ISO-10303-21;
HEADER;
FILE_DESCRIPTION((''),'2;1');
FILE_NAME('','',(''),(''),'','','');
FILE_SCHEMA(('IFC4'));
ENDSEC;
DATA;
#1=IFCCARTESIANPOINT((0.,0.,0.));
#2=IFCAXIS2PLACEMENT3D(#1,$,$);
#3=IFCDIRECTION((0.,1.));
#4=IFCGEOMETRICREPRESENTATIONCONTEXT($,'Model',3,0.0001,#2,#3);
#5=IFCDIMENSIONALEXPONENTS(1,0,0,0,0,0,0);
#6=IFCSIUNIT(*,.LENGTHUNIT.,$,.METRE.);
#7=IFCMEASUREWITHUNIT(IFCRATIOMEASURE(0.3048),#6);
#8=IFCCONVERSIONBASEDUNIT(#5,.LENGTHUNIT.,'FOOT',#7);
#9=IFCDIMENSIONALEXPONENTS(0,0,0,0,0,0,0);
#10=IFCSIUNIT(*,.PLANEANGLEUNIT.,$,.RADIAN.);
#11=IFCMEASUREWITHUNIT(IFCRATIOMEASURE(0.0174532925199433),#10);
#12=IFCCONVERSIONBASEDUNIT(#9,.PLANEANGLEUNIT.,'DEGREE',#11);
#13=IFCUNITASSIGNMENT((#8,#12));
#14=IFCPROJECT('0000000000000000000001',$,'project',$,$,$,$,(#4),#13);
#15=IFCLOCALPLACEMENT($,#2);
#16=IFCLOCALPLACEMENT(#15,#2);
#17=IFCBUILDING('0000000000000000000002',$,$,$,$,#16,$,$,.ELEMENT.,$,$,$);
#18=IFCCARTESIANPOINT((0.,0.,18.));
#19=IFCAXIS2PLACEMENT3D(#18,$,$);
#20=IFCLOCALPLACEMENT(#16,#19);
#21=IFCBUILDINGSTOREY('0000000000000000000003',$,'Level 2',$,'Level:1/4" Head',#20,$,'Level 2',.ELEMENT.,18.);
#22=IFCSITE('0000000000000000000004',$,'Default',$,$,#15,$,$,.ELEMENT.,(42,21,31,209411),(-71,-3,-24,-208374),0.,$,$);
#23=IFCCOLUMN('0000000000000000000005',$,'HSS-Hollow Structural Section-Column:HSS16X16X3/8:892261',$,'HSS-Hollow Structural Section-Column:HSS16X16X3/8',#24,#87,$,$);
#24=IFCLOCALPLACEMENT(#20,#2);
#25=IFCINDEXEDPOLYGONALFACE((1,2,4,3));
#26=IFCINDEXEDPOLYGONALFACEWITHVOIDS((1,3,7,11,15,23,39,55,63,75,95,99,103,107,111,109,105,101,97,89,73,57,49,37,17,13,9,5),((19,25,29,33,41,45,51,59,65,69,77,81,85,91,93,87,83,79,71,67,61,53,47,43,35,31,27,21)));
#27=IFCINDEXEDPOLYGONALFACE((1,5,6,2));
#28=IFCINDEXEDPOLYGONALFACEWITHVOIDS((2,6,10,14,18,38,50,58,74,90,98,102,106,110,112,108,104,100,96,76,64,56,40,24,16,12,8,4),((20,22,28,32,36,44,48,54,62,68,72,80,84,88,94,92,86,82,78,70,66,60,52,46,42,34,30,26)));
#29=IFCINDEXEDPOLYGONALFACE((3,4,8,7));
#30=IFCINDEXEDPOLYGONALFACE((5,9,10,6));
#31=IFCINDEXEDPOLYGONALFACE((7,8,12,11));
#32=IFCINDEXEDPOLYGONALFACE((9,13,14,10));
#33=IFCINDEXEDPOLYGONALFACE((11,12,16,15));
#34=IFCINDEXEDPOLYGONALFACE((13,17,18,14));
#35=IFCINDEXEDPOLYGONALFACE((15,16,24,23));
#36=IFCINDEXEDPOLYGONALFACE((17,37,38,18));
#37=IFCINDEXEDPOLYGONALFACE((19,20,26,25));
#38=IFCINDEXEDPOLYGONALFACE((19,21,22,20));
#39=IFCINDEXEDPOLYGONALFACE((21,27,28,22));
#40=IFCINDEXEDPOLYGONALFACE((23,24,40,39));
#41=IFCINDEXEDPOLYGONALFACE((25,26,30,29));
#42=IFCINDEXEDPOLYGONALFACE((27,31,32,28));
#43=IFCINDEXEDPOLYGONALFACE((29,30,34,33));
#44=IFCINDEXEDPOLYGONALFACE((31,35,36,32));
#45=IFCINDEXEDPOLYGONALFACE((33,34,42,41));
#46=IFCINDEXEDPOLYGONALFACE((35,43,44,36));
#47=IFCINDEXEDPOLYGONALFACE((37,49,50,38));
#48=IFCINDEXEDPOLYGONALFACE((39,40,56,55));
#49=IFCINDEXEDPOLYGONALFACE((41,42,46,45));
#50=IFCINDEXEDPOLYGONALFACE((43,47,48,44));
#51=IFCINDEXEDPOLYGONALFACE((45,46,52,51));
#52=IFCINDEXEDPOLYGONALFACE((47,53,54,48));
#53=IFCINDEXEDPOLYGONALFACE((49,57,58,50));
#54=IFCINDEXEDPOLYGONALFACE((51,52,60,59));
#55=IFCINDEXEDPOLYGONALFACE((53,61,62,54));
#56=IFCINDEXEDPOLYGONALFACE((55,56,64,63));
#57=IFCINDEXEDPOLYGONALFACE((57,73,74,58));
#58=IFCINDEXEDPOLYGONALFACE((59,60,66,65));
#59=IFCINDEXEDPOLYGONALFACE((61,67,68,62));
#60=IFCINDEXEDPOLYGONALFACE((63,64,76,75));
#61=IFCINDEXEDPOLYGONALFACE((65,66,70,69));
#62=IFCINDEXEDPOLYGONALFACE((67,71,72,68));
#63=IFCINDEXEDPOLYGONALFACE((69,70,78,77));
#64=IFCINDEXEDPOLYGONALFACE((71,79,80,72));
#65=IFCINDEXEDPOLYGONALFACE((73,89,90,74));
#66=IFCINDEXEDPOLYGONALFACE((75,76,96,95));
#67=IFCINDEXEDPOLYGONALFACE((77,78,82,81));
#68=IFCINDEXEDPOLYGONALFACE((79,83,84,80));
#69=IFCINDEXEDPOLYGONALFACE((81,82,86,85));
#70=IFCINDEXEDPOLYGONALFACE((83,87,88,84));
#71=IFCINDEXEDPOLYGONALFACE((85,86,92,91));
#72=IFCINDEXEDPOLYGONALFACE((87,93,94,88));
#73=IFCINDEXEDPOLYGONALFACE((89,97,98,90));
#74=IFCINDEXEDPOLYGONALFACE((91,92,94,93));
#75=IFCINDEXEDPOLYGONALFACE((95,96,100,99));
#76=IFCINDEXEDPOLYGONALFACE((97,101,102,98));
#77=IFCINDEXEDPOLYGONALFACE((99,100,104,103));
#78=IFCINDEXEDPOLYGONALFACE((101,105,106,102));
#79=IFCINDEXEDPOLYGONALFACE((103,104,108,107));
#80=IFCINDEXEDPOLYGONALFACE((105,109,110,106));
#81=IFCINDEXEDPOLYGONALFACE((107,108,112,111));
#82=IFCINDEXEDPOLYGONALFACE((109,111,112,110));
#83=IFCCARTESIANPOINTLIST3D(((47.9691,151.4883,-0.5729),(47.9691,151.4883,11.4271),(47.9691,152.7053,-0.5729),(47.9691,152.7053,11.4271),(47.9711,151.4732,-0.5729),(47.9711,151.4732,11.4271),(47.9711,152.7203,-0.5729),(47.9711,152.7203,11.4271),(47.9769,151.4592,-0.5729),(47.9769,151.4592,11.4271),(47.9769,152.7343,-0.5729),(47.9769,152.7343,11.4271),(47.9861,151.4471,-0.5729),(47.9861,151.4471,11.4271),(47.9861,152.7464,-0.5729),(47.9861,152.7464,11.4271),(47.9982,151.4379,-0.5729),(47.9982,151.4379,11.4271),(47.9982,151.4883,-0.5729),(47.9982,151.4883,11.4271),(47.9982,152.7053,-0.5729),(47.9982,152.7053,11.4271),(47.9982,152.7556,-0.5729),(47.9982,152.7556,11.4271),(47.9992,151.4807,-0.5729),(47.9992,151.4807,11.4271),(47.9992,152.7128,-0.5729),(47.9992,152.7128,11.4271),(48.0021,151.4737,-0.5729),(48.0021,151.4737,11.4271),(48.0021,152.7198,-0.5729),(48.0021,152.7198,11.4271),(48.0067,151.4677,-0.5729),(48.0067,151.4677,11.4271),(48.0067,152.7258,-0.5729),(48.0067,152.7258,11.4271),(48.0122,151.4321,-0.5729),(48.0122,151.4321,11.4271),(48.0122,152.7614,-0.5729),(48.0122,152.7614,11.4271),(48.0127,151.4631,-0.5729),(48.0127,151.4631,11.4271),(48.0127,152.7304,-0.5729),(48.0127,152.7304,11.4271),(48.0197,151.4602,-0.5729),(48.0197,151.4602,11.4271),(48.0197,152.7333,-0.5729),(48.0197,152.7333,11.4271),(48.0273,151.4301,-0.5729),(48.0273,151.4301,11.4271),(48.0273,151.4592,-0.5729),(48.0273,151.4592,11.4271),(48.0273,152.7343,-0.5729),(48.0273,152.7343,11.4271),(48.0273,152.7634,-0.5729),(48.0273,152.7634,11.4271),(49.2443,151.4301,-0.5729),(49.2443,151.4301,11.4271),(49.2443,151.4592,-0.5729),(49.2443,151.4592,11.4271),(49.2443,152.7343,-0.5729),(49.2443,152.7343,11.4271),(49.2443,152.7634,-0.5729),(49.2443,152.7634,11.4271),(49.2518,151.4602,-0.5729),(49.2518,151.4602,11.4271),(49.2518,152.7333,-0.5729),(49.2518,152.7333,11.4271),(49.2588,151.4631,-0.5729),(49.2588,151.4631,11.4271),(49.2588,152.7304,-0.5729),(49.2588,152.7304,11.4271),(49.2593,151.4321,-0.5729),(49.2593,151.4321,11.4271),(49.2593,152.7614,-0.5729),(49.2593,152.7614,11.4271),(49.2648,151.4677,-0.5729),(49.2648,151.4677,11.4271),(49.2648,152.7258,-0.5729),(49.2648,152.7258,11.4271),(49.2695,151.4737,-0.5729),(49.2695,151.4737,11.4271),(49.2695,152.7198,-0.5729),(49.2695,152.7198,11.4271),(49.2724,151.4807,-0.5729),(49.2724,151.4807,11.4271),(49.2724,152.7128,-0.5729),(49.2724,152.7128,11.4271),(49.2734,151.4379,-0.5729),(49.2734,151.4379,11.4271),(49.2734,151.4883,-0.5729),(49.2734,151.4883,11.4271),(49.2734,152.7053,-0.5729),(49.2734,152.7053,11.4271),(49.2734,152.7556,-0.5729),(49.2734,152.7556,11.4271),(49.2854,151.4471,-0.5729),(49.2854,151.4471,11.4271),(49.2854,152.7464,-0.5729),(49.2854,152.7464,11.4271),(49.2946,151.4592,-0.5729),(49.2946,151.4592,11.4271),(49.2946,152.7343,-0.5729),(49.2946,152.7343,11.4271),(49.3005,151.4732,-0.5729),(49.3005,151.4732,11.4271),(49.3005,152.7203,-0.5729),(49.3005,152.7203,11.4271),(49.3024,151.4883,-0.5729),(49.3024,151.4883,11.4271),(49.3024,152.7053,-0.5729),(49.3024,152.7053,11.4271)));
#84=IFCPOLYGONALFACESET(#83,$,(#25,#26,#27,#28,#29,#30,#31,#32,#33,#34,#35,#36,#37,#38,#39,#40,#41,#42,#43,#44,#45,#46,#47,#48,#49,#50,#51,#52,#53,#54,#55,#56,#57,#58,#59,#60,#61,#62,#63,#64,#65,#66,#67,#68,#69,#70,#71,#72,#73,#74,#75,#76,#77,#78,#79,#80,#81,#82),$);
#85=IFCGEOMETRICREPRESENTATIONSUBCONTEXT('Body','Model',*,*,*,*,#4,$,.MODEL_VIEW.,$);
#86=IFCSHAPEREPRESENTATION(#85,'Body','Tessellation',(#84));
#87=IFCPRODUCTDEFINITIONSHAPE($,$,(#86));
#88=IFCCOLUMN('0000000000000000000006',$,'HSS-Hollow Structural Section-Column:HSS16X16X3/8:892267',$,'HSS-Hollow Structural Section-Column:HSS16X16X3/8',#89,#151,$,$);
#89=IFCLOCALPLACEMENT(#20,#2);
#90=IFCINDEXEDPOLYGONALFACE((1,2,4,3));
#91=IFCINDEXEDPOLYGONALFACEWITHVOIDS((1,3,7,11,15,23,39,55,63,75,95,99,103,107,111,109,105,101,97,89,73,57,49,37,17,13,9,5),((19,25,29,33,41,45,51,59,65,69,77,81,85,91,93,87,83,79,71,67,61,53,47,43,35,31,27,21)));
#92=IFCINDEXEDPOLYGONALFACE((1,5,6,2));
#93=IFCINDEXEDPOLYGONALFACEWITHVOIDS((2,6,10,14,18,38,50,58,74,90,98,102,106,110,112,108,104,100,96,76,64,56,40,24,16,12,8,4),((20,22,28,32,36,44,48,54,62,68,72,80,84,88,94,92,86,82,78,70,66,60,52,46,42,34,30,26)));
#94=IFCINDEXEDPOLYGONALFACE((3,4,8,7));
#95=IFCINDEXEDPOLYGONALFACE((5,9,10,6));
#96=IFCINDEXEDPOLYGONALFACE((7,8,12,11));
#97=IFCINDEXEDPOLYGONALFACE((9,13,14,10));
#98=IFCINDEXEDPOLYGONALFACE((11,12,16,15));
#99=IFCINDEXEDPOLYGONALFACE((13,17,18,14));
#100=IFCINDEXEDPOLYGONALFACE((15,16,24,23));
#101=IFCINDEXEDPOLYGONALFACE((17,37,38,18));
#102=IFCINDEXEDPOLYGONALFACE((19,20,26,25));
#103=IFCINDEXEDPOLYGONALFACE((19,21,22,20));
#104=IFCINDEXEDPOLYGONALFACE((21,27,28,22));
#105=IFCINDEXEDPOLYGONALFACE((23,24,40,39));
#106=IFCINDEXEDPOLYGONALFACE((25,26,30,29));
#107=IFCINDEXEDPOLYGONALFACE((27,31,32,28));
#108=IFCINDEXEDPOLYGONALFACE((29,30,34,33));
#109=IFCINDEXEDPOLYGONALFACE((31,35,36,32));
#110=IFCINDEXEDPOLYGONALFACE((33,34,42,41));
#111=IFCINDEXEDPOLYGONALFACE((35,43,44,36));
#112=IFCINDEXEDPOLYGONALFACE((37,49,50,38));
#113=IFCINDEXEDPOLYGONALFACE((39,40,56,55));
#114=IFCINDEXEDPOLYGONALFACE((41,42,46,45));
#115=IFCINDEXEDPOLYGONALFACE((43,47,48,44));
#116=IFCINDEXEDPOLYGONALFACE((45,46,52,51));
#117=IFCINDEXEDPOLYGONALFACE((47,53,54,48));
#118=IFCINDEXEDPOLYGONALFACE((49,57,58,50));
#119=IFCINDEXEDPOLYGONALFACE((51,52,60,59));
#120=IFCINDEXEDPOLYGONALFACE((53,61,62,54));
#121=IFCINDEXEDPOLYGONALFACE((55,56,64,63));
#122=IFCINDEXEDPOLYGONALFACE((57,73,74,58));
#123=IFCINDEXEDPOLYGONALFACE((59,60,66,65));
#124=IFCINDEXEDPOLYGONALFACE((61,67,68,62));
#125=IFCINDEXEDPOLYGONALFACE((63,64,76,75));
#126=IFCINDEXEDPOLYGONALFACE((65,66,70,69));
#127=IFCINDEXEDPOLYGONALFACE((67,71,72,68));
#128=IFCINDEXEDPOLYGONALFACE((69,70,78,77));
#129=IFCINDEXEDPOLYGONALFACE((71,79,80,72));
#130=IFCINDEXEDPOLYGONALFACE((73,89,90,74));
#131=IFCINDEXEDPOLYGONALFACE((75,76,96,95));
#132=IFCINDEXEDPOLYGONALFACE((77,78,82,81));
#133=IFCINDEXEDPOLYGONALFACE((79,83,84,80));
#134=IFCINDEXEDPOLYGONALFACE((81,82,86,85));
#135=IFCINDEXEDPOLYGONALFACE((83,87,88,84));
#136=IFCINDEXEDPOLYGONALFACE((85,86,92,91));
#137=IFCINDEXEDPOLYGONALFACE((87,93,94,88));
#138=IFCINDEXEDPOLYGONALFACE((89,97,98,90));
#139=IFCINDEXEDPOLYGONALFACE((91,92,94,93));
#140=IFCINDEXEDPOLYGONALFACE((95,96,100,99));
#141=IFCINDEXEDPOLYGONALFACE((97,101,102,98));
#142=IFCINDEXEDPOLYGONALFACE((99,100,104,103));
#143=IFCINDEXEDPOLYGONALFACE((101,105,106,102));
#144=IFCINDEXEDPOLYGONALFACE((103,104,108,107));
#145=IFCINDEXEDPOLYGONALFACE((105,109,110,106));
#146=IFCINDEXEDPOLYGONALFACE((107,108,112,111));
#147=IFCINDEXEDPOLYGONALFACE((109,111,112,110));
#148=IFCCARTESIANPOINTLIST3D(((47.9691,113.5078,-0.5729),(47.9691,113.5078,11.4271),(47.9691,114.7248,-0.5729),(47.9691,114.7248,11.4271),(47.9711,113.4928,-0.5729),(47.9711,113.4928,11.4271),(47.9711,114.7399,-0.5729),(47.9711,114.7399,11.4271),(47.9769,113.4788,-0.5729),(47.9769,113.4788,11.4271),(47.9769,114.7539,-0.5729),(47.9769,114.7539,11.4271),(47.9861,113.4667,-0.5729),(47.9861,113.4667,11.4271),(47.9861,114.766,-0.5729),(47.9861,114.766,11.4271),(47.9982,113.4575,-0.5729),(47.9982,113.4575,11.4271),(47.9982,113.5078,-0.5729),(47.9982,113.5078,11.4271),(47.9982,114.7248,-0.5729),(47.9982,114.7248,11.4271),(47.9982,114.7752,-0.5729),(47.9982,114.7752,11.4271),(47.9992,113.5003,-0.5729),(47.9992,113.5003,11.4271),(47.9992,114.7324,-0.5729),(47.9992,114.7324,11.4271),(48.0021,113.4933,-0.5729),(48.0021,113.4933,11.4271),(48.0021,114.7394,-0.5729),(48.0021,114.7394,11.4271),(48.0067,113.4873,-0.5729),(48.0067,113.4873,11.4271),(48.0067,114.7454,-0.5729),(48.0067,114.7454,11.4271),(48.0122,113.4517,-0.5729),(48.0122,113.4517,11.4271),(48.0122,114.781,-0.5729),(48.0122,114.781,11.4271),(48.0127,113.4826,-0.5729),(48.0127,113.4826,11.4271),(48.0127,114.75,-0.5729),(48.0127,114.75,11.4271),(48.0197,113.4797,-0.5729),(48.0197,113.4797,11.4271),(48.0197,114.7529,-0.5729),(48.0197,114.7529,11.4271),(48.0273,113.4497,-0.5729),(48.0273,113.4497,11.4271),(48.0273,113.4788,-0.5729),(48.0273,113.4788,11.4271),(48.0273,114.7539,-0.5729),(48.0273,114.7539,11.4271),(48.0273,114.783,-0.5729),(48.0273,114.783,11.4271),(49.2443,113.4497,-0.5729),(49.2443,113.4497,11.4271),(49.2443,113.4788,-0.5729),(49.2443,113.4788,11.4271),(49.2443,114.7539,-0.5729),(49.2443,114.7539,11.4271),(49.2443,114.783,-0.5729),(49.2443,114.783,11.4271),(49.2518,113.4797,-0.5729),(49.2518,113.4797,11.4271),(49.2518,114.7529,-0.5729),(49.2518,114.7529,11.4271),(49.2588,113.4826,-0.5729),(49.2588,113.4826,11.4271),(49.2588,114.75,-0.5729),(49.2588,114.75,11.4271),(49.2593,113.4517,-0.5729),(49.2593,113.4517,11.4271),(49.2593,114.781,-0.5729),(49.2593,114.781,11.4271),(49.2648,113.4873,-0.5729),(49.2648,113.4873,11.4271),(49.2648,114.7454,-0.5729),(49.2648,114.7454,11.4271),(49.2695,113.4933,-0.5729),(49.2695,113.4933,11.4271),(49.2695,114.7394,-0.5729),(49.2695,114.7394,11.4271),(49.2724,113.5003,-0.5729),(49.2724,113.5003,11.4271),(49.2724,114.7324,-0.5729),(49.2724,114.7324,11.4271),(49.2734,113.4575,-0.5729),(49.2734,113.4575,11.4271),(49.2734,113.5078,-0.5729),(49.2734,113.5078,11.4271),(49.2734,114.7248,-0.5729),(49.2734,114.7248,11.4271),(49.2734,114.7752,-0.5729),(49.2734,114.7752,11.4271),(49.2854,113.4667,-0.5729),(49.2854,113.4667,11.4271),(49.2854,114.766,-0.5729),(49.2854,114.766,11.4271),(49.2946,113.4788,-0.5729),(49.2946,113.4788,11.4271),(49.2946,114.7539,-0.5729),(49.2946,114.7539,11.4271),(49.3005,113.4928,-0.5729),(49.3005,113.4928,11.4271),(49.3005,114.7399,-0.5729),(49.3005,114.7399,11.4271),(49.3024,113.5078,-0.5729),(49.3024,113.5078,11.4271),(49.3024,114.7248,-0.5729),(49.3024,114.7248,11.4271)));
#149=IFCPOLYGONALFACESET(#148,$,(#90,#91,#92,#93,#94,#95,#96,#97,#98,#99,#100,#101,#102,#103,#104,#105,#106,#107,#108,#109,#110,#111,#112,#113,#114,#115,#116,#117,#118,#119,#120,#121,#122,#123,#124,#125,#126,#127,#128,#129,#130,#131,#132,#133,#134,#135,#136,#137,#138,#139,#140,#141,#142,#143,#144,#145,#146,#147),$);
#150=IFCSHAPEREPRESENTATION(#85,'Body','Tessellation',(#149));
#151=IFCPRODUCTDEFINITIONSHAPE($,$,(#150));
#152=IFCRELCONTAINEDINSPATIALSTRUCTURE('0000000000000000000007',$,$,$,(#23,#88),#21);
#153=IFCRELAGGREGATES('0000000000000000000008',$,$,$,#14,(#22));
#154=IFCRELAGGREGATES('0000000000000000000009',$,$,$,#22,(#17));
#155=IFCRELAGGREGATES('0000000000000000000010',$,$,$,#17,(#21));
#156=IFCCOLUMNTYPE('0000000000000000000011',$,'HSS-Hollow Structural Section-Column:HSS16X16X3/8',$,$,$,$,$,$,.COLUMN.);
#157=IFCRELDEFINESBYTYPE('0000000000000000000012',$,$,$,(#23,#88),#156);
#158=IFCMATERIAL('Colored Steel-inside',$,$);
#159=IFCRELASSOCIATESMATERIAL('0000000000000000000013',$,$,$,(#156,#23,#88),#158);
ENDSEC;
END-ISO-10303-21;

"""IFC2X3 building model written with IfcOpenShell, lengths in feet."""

from ifc_helpers import new_model, entity, si_unit, converted_unit, direction, frame, frame_2d, origin, place, context, subcontext, project, spatial, polyline, circle_curve, parameter, trimmed, segment, composite_curve, outline, extrude, source, transform, mapped, material, type_object, type_shapes, element, save


model = new_model("IFC2X3")

# Units and contexts
model_context = context("Model", 3, precision=0.0001, world=origin(), true_north=direction((0.0, 1.0)))
body_context = subcontext(model_context, "Body", "Model", "MODEL_VIEW")
ifc_project = project(units=[converted_unit("LENGTHUNIT", "FOOT", entity("IfcRatioMeasure", 0.3048), si_unit("LENGTHUNIT", "METRE"), dimensions=[1, 0, 0, 0, 0, 0, 0]), converted_unit("PLANEANGLEUNIT", "DEGREE", entity("IfcRatioMeasure", 0.0174532925199433), si_unit("PLANEANGLEUNIT", "RADIAN"), dimensions=[0, 0, 0, 0, 0, 0, 0])], contexts=[model_context])

# Site, building, storey
site_placement = place(None, origin())
site = spatial("IfcSite", under=ifc_project, at=site_placement, Name="Default", CompositionType="ELEMENT", RefLatitude=(42, 21, 31, 209411), RefLongitude=(-71, -3, -24, -208374), RefElevation=0.0)
building_placement = place(site_placement, origin())
building = spatial("IfcBuilding", under=site, at=building_placement, CompositionType="ELEMENT")
storey_placement = place(building_placement, frame((0.0, 0.0, 18.0)))
storey = spatial("IfcBuildingStorey", under=building, at=storey_placement, Name="Level 2", ObjectType="Level:1/4\" Head", LongName="Level 2", CompositionType="ELEMENT", Elevation=18.0)

# Columns
ifc_material_1 = material(Name="Colored Steel-inside")
column_type = type_object("IfcColumnType", Name="HSS-Hollow Structural Section-Column:HSS16X16X3/8", PredefinedType="COLUMN", material=ifc_material_1)
shared_shape = source(origin(), body_context, "Body", "SweptSolid", [
    extrude(outline(composite_curve([segment(polyline([(-0.6085, -0.6667), (0.6085, -0.6667)]), True, "CONTINUOUS"), segment(trimmed(circle_curve(frame_2d((0.6085, -0.6085), x_axis=(-1.0, 0.0)), 0.0582), [parameter(90.0)], [parameter(180.0)], True, "PARAMETER"), True, "CONTINUOUS"), segment(polyline([(0.6667, -0.6085), (0.6667, 0.6085)]), True, "CONTINUOUS"), segment(trimmed(circle_curve(frame_2d((0.6085, 0.6085), x_axis=(-1.0, 0.0)), 0.0582), [parameter(180.0)], [parameter(270.0)], True, "PARAMETER"), True, "CONTINUOUS"), segment(polyline([(0.6085, 0.6667), (-0.6085, 0.6667)]), True, "CONTINUOUS"), segment(trimmed(circle_curve(frame_2d((-0.6085, 0.6085), x_axis=(-1.0, 0.0)), 0.0582), [parameter(270.0)], [parameter(360.0)], True, "PARAMETER"), True, "CONTINUOUS"), segment(polyline([(-0.6667, 0.6085), (-0.6667, -0.6085)]), True, "CONTINUOUS"), segment(trimmed(circle_curve(frame_2d((-0.6085, -0.6085), x_axis=(-1.0, 0.0)), 0.0582), [parameter(360.0)], [parameter(90.0)], True, "PARAMETER"), True, "CONTINUOUS")], self_intersect=False), holes=[composite_curve([segment(trimmed(circle_curve(frame_2d((-0.6085, -0.6085), x_axis=(-1.0, 0.0)), 0.0291), [parameter(0.0)], [parameter(90.0)], True, "PARAMETER"), False, "CONTINUOUS"), segment(polyline([(-0.6376, -0.6085), (-0.6376, 0.6085)]), True, "CONTINUOUS"), segment(trimmed(circle_curve(frame_2d((-0.6085, 0.6085), x_axis=(-1.0, 0.0)), 0.0291), [parameter(270.0)], [parameter(360.0)], True, "PARAMETER"), False, "CONTINUOUS"), segment(polyline([(-0.6085, 0.6376), (0.6085, 0.6376)]), True, "CONTINUOUS"), segment(trimmed(circle_curve(frame_2d((0.6085, 0.6085), x_axis=(-1.0, 0.0)), 0.0291), [parameter(180.0)], [parameter(270.0)], True, "PARAMETER"), False, "CONTINUOUS"), segment(polyline([(0.6376, 0.6085), (0.6376, -0.6085)]), True, "CONTINUOUS"), segment(trimmed(circle_curve(frame_2d((0.6085, -0.6085), x_axis=(-1.0, 0.0)), 0.0291), [parameter(90.0)], [parameter(180.0)], True, "PARAMETER"), False, "CONTINUOUS"), segment(polyline([(0.6085, -0.6376), (-0.6085, -0.6376)]), True, "CONTINUOUS")], self_intersect=False)]), frame((0.0, 0.0, 17.4271), z_axis=(0.0, 0.0, 1.0), x_axis=(-1.0, 0.0, 0.0)), (0.0, 0.0, 1.0), 12.0),
])
type_shapes(column_type, [shared_shape])
for number, where, name in (
    (1, (48.6358, 152.0968, -18.0), "HSS-Hollow Structural Section-Column:HSS16X16X3/8:892261"),
    (2, (48.6358, 114.1163, -18.0), "HSS-Hollow Structural Section-Column:HSS16X16X3/8:892267"),
):
    element("IfcColumn", number, at=place(storey_placement, frame(where)), inside=storey, type_object=column_type, material=ifc_material_1, Name=name, ObjectType="HSS-Hollow Structural Section-Column:HSS16X16X3/8", context=body_context, shape_type="MappedRepresentation", body=[
        mapped(shared_shape, transform((0.0, 0.0, 0.0), scale=1.0)),
    ])

save(model, "model.ifc")
